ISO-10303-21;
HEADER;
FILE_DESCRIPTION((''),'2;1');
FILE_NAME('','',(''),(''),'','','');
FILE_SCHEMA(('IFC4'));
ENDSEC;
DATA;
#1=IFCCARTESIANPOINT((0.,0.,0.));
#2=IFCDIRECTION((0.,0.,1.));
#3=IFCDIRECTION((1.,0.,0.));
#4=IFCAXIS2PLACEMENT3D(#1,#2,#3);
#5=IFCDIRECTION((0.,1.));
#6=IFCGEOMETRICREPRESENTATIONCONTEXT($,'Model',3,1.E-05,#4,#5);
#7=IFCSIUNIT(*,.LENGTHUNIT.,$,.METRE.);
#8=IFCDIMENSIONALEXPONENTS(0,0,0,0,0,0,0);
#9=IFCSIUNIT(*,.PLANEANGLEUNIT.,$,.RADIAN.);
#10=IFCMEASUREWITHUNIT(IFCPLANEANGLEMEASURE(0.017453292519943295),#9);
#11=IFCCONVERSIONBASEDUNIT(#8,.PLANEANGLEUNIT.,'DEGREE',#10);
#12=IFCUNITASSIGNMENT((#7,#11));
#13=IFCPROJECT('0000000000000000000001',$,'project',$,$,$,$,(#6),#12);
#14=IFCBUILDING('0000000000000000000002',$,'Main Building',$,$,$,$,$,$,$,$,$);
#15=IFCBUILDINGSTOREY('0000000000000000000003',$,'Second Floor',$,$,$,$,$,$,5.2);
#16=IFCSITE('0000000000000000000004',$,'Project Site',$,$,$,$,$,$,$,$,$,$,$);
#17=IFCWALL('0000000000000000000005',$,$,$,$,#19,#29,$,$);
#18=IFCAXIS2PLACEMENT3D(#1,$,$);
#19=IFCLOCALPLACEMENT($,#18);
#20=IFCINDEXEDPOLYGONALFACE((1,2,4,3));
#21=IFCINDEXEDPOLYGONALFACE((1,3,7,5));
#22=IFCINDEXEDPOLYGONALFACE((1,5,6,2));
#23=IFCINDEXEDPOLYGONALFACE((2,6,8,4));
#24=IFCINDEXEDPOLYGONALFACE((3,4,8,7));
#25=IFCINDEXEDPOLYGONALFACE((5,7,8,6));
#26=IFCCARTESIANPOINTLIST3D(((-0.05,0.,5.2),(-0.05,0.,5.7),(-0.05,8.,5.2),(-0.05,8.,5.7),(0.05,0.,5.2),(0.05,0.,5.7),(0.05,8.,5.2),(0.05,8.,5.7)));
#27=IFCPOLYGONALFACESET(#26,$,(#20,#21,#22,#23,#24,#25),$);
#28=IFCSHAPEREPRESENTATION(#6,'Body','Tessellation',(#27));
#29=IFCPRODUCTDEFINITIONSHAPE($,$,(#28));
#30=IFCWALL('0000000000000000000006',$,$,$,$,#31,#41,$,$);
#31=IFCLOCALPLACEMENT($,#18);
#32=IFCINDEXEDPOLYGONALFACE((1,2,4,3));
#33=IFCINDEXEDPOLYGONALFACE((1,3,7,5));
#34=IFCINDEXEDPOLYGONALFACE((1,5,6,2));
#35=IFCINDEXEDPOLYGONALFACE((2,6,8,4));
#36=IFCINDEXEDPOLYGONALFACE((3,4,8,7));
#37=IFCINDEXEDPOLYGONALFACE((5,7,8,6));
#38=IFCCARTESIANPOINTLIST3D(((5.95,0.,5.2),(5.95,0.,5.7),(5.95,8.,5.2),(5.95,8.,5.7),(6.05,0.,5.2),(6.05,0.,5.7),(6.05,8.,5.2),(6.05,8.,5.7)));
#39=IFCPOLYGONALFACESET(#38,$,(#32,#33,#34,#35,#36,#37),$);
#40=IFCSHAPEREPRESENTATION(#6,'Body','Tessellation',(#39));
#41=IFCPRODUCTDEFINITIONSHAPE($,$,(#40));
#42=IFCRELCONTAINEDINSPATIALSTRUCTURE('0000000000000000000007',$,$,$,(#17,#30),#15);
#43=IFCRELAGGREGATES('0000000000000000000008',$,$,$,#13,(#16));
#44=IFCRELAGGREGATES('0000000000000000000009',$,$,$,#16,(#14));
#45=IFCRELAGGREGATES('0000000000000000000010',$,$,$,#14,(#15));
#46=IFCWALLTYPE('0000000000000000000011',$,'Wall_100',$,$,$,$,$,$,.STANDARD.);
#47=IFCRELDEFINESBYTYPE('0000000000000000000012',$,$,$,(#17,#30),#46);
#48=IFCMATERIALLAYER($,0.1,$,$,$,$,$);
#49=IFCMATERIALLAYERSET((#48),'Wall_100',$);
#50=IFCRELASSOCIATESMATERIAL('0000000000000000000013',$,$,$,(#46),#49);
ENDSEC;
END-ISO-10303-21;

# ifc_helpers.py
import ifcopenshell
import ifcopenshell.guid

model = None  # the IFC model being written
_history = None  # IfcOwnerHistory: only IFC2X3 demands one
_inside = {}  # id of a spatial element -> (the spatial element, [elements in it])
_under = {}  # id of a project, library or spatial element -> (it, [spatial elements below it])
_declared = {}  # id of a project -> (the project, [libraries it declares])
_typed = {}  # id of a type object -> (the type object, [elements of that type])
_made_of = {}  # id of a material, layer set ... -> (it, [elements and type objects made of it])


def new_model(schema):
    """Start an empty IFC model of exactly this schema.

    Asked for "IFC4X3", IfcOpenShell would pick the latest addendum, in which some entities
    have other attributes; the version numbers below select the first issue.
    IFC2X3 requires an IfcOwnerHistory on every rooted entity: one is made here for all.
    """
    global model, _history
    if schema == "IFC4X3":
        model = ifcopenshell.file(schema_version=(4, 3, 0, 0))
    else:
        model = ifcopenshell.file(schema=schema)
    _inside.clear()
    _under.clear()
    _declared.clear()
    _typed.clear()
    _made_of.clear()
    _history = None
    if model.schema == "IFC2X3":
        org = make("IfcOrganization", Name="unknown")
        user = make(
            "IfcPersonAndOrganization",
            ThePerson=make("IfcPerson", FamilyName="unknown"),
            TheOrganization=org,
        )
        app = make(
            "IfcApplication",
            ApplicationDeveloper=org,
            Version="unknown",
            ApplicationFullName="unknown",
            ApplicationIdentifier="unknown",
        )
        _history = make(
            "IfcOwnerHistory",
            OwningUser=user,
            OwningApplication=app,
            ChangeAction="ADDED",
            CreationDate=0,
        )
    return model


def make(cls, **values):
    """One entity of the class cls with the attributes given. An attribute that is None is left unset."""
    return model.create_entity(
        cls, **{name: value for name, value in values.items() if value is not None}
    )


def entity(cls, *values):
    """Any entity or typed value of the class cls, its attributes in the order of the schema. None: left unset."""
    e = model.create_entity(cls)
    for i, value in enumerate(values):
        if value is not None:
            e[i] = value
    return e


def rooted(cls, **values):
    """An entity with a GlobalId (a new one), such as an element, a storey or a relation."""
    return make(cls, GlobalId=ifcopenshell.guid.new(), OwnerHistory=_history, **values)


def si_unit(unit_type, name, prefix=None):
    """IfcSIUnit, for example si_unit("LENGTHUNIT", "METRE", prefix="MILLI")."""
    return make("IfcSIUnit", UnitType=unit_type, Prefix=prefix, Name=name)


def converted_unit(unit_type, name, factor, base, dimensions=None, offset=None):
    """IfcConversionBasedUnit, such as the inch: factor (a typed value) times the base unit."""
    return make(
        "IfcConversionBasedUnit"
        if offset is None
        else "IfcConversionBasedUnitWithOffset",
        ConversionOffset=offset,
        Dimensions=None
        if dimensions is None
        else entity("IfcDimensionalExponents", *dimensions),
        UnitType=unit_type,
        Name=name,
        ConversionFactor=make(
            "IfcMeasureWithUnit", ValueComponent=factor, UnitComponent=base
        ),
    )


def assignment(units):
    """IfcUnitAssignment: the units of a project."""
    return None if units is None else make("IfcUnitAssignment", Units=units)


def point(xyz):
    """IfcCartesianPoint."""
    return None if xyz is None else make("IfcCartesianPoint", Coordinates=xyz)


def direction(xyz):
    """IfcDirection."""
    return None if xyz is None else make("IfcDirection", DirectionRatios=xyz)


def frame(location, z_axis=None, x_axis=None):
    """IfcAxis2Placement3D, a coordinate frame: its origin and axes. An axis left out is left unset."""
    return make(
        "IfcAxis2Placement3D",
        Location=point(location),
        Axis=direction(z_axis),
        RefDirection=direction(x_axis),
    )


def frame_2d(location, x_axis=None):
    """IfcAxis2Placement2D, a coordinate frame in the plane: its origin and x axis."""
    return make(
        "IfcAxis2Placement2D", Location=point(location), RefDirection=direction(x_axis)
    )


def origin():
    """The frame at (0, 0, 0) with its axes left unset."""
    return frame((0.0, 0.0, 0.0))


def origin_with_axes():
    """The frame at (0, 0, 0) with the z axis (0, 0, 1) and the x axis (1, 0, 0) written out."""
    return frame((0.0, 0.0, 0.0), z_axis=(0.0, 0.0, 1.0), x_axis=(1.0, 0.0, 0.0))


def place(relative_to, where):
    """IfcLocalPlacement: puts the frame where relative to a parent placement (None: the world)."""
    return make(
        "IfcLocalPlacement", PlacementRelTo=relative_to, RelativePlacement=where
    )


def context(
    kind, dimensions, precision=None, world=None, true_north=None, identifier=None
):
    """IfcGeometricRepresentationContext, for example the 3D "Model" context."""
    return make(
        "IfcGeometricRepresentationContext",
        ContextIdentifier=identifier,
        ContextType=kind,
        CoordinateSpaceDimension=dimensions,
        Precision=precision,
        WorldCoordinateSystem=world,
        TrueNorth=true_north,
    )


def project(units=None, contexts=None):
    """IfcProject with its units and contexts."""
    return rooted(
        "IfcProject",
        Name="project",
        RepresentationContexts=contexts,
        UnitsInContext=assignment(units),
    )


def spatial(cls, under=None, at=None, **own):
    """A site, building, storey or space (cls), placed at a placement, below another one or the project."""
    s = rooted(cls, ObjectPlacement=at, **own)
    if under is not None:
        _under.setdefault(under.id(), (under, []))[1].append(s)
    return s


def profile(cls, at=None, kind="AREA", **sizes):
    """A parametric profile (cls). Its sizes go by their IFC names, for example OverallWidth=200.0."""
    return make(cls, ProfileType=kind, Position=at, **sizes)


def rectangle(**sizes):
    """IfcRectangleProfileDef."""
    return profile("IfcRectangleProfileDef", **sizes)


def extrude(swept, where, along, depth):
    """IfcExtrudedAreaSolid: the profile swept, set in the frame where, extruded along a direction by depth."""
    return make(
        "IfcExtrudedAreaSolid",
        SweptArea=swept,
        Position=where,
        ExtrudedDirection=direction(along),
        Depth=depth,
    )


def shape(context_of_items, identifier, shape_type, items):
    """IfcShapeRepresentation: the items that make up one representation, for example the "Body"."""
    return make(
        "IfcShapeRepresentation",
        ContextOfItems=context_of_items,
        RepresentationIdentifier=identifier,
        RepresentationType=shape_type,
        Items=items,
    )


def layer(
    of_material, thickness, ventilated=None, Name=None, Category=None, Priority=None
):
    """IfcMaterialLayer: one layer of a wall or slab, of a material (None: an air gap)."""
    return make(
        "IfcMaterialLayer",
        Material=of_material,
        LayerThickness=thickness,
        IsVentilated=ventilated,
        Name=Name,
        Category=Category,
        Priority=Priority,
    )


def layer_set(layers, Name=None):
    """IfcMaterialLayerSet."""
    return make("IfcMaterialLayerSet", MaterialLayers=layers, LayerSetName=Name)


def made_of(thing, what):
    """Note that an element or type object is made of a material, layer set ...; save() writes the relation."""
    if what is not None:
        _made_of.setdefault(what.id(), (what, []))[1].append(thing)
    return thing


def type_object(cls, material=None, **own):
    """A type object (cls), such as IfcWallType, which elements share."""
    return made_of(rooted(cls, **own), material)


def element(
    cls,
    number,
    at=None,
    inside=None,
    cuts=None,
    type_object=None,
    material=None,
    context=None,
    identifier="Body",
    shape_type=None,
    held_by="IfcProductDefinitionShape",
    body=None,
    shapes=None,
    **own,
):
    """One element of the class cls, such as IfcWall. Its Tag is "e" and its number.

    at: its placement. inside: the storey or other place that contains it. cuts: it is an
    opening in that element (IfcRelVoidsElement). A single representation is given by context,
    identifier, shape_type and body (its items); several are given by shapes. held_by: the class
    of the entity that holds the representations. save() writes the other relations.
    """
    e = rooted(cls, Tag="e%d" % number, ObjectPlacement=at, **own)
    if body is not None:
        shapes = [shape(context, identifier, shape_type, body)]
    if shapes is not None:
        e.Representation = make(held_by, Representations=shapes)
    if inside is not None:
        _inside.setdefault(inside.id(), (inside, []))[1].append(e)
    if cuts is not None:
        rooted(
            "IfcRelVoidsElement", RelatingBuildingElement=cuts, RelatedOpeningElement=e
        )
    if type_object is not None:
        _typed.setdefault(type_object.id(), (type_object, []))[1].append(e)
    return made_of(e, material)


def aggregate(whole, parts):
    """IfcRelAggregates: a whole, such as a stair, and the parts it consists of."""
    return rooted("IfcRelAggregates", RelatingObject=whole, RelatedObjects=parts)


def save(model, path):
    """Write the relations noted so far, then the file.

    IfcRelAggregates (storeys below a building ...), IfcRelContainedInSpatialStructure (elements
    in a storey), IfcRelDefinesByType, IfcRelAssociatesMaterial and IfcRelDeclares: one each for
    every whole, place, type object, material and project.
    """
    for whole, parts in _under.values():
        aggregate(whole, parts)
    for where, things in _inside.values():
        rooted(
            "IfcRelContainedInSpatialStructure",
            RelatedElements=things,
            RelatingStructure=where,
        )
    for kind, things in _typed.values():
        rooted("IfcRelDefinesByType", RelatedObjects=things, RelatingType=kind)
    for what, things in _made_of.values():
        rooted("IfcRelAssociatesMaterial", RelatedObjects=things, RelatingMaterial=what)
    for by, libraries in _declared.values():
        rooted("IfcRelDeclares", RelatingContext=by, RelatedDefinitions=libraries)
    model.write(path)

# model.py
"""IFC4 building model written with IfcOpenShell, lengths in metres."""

from ifc_helpers import new_model, entity, si_unit, converted_unit, direction, frame, frame_2d, origin, origin_with_axes, place, context, project, spatial, rectangle, extrude, layer, layer_set, type_object, element, save


model = new_model("IFC4")

# Units and contexts
model_context = context("Model", 3, precision=1e-05, world=origin_with_axes(), true_north=direction((0.0, 1.0)))
ifc_project = project(units=[si_unit("LENGTHUNIT", "METRE"), converted_unit("PLANEANGLEUNIT", "DEGREE", entity("IfcPlaneAngleMeasure", 0.017453292519943295), si_unit("PLANEANGLEUNIT", "RADIAN"), dimensions=[0, 0, 0, 0, 0, 0, 0])], contexts=[model_context])

# Site, building, storey
site = spatial("IfcSite", under=ifc_project, Name="Project Site")
building = spatial("IfcBuilding", under=site, Name="Main Building")
storey = spatial("IfcBuildingStorey", under=building, Name="Second Floor", Elevation=5.2)

# Walls
ifc_layer_1 = layer(None, 0.1)
ifc_layer_set_1 = layer_set([ifc_layer_1], Name="Wall_100")
wall_type = type_object("IfcWallType", Name="Wall_100", PredefinedType="STANDARD", material=ifc_layer_set_1)
for number, where, z_axis, x_axis in (
    (1, (0.0, 0.0, 5.2), (0.0, 0.0, 1.0), (0.0, 1.0, 0.0)),
    (2, (6.0, 0.0, 5.2), (0.0, 0.0, 1.0), (0.0, 1.0, 0.0)),
):
    element("IfcWall", number, at=place(None, frame(where, z_axis=z_axis, x_axis=x_axis)), inside=storey, type_object=wall_type, context=model_context, shape_type="SweptSolid", body=[
        extrude(rectangle(XDim=8.0, YDim=0.1, at=frame_2d((4.0, 0.0))), origin(), (0.0, 0.0, 1.0), 0.5),
    ])

save(model, "model.ifc")
